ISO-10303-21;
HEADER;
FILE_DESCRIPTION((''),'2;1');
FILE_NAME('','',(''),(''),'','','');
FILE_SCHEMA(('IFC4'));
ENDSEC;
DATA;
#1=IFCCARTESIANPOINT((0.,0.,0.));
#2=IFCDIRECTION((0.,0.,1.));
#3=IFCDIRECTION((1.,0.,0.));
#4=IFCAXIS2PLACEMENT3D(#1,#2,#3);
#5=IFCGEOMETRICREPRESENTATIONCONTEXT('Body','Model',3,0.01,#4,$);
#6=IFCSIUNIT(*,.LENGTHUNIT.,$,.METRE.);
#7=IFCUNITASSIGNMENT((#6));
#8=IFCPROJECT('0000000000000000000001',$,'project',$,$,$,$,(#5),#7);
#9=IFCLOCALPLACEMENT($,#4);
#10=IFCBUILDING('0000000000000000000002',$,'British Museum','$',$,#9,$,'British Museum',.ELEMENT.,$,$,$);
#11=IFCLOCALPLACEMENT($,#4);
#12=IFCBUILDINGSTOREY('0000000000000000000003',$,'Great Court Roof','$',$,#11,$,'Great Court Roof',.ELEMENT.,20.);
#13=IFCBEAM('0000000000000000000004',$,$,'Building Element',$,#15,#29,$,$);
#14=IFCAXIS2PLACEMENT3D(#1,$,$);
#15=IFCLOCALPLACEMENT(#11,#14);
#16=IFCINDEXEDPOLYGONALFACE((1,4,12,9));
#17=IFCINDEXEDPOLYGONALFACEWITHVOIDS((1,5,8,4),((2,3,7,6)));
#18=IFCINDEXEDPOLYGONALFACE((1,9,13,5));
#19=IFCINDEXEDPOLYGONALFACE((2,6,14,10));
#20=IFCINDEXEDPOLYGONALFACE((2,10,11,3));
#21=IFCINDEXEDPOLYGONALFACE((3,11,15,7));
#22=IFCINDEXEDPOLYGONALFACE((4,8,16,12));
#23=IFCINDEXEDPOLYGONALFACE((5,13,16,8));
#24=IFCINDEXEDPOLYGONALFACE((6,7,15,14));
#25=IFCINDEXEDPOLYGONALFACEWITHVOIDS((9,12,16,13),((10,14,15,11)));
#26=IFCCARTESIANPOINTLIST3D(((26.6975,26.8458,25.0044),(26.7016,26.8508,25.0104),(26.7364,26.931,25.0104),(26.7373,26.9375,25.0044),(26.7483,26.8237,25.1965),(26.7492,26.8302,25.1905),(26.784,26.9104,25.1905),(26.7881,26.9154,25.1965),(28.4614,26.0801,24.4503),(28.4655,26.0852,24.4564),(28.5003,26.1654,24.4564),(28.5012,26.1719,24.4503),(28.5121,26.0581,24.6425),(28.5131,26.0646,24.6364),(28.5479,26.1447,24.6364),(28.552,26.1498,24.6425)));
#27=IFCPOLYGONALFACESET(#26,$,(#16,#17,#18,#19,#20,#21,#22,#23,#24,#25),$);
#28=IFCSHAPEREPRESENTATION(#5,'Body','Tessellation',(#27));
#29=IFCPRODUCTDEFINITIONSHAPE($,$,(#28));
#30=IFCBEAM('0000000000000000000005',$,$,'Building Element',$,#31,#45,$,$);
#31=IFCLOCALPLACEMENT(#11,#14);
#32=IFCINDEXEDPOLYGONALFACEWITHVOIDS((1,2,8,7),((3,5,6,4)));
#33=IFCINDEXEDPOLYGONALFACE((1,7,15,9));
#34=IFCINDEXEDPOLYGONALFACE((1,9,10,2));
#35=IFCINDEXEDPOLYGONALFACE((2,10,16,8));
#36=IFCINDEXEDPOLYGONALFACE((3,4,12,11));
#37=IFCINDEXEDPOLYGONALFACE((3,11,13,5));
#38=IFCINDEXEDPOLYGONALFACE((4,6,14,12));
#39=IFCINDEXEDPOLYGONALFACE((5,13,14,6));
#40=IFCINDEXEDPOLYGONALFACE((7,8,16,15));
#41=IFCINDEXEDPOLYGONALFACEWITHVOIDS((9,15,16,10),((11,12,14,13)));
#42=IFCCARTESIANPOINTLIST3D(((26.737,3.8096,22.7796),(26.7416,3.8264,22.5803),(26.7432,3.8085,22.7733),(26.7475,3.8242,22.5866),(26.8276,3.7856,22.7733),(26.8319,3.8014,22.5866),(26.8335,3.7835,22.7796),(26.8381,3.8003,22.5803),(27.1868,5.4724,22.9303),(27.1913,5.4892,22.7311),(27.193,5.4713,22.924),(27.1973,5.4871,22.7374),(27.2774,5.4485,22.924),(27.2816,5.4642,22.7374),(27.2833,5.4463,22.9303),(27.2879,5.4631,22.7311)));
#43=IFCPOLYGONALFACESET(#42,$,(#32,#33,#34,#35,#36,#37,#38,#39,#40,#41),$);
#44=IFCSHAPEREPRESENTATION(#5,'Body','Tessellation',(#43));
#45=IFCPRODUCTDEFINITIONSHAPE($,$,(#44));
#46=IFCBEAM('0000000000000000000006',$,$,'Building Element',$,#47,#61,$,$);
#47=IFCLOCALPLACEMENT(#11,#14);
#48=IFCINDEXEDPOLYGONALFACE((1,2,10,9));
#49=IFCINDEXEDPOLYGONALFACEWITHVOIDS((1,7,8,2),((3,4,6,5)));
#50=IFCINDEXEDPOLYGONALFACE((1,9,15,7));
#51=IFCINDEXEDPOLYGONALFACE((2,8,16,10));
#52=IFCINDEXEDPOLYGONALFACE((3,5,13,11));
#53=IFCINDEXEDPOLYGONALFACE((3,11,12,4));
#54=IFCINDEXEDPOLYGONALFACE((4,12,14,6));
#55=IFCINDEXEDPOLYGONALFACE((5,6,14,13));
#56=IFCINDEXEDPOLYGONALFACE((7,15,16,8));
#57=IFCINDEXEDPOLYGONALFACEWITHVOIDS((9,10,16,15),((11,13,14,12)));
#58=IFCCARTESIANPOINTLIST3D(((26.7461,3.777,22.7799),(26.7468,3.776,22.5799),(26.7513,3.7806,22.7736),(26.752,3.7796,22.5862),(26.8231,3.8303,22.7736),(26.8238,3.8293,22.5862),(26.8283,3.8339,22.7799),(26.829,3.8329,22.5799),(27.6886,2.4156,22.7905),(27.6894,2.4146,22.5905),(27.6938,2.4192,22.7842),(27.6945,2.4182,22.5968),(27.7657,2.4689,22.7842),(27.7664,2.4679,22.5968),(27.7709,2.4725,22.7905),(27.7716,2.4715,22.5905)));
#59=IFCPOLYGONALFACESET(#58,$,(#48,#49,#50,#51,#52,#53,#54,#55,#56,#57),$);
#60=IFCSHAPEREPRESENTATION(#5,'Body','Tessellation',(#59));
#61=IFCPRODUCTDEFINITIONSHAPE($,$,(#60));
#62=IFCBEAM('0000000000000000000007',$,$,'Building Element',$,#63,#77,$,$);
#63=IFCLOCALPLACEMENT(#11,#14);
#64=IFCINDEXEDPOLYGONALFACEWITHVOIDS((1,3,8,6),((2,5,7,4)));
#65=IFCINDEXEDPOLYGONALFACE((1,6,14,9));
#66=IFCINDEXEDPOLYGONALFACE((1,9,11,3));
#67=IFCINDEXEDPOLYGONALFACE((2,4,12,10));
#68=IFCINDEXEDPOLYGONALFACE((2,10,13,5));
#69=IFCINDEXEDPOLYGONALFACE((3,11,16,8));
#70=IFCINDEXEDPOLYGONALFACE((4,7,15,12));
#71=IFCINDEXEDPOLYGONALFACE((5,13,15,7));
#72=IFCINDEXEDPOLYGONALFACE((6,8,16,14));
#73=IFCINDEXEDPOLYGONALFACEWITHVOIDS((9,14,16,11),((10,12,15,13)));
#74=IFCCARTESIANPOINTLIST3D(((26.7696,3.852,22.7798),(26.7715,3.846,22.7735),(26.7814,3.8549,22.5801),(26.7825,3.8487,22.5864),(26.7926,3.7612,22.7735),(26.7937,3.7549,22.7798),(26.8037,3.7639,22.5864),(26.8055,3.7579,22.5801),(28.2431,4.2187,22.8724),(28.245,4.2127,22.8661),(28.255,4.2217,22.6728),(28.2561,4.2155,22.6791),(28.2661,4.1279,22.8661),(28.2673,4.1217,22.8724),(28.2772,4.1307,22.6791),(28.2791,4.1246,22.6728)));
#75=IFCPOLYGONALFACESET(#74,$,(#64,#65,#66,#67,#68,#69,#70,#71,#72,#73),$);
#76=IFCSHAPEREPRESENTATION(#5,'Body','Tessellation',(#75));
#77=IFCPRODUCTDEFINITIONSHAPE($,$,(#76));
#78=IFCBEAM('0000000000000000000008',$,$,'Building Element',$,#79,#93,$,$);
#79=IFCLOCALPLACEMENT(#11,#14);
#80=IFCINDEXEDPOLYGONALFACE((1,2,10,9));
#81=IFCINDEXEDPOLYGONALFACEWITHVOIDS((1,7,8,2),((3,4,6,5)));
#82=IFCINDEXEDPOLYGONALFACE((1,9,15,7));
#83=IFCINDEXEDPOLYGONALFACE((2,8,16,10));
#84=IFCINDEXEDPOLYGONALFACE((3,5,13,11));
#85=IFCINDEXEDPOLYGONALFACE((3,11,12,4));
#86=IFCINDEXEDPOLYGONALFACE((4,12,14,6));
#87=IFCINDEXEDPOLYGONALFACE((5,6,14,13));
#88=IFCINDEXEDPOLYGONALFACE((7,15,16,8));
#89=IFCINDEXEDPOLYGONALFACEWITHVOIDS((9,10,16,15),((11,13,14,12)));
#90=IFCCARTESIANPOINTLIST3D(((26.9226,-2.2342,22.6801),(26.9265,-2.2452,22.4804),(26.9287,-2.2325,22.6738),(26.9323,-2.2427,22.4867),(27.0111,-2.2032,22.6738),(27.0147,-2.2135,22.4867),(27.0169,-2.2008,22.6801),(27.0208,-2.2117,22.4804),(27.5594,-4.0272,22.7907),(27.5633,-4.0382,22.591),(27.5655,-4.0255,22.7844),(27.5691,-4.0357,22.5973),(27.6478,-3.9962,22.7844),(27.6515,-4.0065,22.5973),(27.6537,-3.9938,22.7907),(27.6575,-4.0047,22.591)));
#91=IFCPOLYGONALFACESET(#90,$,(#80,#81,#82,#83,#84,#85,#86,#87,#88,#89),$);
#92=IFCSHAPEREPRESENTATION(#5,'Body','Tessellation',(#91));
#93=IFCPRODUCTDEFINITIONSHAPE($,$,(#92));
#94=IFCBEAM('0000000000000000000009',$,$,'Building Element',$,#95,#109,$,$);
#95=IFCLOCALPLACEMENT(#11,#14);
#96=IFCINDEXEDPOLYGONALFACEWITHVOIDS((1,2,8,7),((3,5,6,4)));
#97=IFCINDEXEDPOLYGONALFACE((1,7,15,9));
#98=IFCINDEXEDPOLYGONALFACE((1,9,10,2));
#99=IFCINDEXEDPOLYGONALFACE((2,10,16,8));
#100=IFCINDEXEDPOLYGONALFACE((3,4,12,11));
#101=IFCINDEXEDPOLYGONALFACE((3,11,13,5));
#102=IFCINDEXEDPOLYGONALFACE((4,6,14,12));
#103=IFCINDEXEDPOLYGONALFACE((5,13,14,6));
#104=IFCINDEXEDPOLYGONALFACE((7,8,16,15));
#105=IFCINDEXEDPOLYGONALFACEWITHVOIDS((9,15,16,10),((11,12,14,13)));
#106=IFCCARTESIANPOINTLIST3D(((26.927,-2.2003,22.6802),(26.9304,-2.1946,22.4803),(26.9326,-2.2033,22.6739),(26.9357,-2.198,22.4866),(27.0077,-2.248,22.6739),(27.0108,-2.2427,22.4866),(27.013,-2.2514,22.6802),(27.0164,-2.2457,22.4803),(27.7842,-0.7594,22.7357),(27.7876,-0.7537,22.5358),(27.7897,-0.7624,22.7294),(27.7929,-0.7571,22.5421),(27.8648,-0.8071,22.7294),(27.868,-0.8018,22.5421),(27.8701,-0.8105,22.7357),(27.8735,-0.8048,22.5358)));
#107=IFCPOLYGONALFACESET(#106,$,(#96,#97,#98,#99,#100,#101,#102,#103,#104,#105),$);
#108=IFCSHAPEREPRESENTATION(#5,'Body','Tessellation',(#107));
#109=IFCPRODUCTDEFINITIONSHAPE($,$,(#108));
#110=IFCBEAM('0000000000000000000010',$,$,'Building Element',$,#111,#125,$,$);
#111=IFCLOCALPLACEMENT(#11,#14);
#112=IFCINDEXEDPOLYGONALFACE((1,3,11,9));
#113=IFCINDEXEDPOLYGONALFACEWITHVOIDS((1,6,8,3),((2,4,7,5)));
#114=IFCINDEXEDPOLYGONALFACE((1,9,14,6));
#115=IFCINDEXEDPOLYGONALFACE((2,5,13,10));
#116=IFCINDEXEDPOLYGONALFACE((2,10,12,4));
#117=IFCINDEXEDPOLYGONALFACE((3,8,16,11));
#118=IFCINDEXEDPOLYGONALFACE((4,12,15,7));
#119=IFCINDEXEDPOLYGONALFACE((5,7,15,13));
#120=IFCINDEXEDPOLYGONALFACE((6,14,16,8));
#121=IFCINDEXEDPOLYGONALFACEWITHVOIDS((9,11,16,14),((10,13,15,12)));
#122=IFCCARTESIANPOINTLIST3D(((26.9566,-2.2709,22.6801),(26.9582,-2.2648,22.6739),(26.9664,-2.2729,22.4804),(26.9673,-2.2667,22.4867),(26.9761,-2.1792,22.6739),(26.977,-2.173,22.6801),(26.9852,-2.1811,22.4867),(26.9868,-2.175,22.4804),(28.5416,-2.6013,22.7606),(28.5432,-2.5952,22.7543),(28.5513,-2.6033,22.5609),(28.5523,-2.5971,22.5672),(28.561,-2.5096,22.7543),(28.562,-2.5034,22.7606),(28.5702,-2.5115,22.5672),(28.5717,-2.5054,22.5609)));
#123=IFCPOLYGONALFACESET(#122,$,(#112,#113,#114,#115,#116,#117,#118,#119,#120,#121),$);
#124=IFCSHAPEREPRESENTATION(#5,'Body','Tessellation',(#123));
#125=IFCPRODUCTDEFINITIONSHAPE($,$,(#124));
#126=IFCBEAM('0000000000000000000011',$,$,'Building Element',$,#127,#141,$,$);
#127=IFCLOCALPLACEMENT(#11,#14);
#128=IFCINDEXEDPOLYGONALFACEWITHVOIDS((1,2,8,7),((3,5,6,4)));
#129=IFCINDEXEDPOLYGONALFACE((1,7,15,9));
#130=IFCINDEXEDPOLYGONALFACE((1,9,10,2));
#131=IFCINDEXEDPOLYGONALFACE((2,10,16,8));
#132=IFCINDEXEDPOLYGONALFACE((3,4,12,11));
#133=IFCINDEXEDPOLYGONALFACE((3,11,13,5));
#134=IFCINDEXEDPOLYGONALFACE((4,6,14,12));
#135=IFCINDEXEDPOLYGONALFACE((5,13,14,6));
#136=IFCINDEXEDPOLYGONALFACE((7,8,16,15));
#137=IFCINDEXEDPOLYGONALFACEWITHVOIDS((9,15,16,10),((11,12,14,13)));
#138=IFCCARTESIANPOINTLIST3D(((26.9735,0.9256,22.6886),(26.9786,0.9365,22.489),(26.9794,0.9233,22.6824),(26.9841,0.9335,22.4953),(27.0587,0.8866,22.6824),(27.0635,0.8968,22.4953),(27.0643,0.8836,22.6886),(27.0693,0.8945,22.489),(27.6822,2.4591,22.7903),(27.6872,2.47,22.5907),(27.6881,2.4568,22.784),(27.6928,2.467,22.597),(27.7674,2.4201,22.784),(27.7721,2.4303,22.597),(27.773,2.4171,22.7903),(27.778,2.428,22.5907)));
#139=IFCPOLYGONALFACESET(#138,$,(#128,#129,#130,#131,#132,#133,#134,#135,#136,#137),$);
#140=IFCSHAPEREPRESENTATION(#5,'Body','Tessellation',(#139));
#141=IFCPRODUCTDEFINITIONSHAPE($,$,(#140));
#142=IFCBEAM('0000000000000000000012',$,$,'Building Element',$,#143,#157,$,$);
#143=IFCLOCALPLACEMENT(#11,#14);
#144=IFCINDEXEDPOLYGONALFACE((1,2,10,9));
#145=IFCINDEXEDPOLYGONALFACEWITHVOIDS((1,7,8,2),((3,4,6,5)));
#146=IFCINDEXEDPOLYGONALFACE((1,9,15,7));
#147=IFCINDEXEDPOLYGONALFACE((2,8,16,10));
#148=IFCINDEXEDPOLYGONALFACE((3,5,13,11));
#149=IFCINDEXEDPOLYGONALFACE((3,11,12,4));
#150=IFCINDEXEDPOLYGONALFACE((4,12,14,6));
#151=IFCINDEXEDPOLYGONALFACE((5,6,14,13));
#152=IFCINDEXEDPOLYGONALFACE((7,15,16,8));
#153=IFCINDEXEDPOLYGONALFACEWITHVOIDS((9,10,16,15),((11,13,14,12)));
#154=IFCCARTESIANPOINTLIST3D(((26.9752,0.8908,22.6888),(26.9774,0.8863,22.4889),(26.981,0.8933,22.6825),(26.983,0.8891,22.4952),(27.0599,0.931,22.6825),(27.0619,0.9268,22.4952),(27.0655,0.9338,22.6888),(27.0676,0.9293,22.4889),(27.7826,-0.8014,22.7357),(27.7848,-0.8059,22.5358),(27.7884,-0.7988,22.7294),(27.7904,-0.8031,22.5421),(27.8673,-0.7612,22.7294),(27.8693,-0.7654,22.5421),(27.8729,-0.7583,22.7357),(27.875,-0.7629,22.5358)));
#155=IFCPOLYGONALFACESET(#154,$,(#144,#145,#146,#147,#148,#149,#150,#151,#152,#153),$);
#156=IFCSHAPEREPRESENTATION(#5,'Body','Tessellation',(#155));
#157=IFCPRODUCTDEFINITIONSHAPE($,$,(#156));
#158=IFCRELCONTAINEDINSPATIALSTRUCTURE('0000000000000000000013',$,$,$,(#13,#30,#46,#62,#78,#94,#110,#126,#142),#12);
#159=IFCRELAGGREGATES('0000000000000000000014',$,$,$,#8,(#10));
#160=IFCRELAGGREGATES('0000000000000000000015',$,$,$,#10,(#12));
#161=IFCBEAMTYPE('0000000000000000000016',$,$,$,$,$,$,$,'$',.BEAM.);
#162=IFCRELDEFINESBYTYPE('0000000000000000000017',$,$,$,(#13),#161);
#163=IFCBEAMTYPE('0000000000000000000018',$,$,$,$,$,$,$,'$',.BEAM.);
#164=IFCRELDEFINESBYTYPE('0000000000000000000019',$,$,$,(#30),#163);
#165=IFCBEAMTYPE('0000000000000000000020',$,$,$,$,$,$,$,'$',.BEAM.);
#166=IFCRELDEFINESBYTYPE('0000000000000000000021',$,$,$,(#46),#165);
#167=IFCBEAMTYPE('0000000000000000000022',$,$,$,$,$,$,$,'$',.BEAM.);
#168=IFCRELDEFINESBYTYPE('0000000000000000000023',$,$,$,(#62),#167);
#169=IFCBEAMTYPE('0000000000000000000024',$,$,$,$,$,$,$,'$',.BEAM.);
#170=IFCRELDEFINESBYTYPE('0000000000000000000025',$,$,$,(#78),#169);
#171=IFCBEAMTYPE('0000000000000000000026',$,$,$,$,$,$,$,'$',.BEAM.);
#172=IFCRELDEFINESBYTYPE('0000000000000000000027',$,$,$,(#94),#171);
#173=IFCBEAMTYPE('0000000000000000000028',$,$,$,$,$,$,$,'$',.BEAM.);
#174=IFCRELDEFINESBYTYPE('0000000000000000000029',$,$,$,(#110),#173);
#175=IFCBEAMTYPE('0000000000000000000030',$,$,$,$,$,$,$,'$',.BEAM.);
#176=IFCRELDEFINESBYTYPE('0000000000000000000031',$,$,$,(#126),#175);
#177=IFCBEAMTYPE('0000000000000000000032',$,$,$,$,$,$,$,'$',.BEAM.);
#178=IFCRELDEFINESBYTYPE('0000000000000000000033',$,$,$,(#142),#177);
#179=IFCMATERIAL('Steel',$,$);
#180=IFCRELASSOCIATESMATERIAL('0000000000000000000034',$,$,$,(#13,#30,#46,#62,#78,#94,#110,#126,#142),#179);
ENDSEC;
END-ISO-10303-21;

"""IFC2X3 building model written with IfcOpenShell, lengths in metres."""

from ifc_helpers import new_model, si_unit, frame, origin_with_axes, origin_2d, place, context, project, spatial, hollow_rectangle, extrude, material, type_object, element, save


model = new_model("IFC2X3")

# Units and contexts
model_context = context("Model", 3, precision=0.01, world=origin_with_axes(), identifier="Body")
ifc_project = project(units=[si_unit("LENGTHUNIT", "METRE")], contexts=[model_context])

# Building, storey
building_placement = place(None, origin_with_axes())
building = spatial("IfcBuilding", under=ifc_project, at=building_placement, Name="British Museum", Description="$", LongName="British Museum", CompositionType="ELEMENT")
storey_placement = place(None, origin_with_axes())
storey = spatial("IfcBuildingStorey", under=building, at=storey_placement, Name="Great Court Roof", Description="$", LongName="Great Court Roof", CompositionType="ELEMENT", Elevation=20.0)

# Beams
ifc_material = material(Name="Steel")
beam_type_1 = type_object("IfcBeamType", ElementType="$", PredefinedType="BEAM")
beam_1_placement = place(None, origin_with_axes())
element("IfcBeam", 1, at=beam_1_placement, inside=storey, type_object=beam_type_1, material=ifc_material, Description="Building Element", context=model_context, shape_type="SweptSolid", body=[
    extrude(hollow_rectangle(XDim=0.1, YDim=0.2, WallThickness=0.0063, InnerFilletRadius=-0.0063, OuterFilletRadius=0.0, at=origin_2d()), frame((26.7428, 26.8806, 25.1005), z_axis=(0.881448, -0.382608, -0.276877), x_axis=(0.398175, 0.91731, 0.0)), (0.0, 0.0, 1.0), 2.0011),
])
beam_type_2 = type_object("IfcBeamType", ElementType="$", PredefinedType="BEAM")
beam_2_placement = place(None, origin_with_axes())
element("IfcBeam", 2, at=beam_2_placement, inside=storey, type_object=beam_type_2, material=ifc_material, Description="Building Element", context=model_context, shape_type="SweptSolid", body=[
    extrude(hollow_rectangle(XDim=0.1, YDim=0.2, WallThickness=0.0063, InnerFilletRadius=-0.0063, OuterFilletRadius=0.0, at=origin_2d()), frame((26.7876, 3.8049, 22.6799), z_axis=(0.260104, 0.961637, 0.087183), x_axis=(-0.965312, 0.261098, 0.0)), (0.0, 0.0, 1.0), 1.7292),
])
beam_type_3 = type_object("IfcBeamType", ElementType="$", PredefinedType="BEAM")
beam_3_placement = place(None, origin_with_axes())
element("IfcBeam", 3, at=beam_3_placement, inside=storey, type_object=beam_type_3, material=ifc_material, Description="Building Element", context=model_context, shape_type="SweptSolid", body=[
    extrude(hollow_rectangle(XDim=0.1, YDim=0.2, WallThickness=0.0063, InnerFilletRadius=-0.0063, OuterFilletRadius=0.0, at=origin_2d()), frame((26.7876, 3.8049, 22.6799), z_axis=(0.569218, -0.822162, 0.006369), x_axis=(0.822178, 0.56923, 0.0)), (0.0, 0.0, 1.0), 1.6559),
])
beam_type_4 = type_object("IfcBeamType", ElementType="$", PredefinedType="BEAM")
beam_4_placement = place(None, origin_with_axes())
element("IfcBeam", 4, at=beam_4_placement, inside=storey, type_object=beam_type_4, material=ifc_material, Description="Building Element", context=model_context, shape_type="SweptSolid", body=[
    extrude(hollow_rectangle(XDim=0.1, YDim=0.2, WallThickness=0.0063, InnerFilletRadius=-0.0063, OuterFilletRadius=0.0, at=origin_2d()), frame((26.7876, 3.8049, 22.6799), z_axis=(0.968596, 0.241063, 0.060918), x_axis=(-0.241512, 0.970398, 0.0)), (0.0, 0.0, 1.0), 1.5213),
])
beam_type_5 = type_object("IfcBeamType", ElementType="$", PredefinedType="BEAM")
beam_5_placement = place(None, origin_with_axes())
element("IfcBeam", 5, at=beam_5_placement, inside=storey, type_object=beam_type_5, material=ifc_material, Description="Building Element", context=model_context, shape_type="SweptSolid", body=[
    extrude(hollow_rectangle(XDim=0.1, YDim=0.2, WallThickness=0.0063, InnerFilletRadius=-0.0063, OuterFilletRadius=0.0, at=origin_2d()), frame((26.9717, -2.223, 22.5803), z_axis=(0.334108, -0.940747, 0.058033), x_axis=(0.942335, 0.334672, 0.0)), (0.0, 0.0, 1.0), 1.9059),
])
beam_type_6 = type_object("IfcBeamType", ElementType="$", PredefinedType="BEAM")
beam_6_placement = place(None, origin_with_axes())
element("IfcBeam", 6, at=beam_6_placement, inside=storey, type_object=beam_type_6, material=ifc_material, Description="Building Element", context=model_context, shape_type="SweptSolid", body=[
    extrude(hollow_rectangle(XDim=0.1, YDim=0.2, WallThickness=0.0063, InnerFilletRadius=-0.0063, OuterFilletRadius=0.0, at=origin_2d()), frame((26.9717, -2.223, 22.5803), z_axis=(0.510977, 0.858958, 0.033064), x_axis=(-0.859428, 0.511257, 0.0)), (0.0, 0.0, 1.0), 1.6774),
])
beam_type_7 = type_object("IfcBeamType", ElementType="$", PredefinedType="BEAM")
beam_7_placement = place(None, origin_with_axes())
element("IfcBeam", 7, at=beam_7_placement, inside=storey, type_object=beam_type_7, material=ifc_material, Description="Building Element", context=model_context, shape_type="SweptSolid", body=[
    extrude(hollow_rectangle(XDim=0.1, YDim=0.2, WallThickness=0.0063, InnerFilletRadius=-0.0063, OuterFilletRadius=0.0, at=origin_2d()), frame((26.9717, -2.223, 22.5803), z_axis=(0.977752, -0.203803, 0.049648), x_axis=(0.204054, 0.97896, 0.0)), (0.0, 0.0, 1.0), 1.621),
])
beam_type_8 = type_object("IfcBeamType", ElementType="$", PredefinedType="BEAM")
beam_8_placement = place(None, origin_with_axes())
element("IfcBeam", 8, at=beam_8_placement, inside=storey, type_object=beam_type_8, material=ifc_material, Description="Building Element", context=model_context, shape_type="SweptSolid", body=[
    extrude(hollow_rectangle(XDim=0.1, YDim=0.2, WallThickness=0.0063, InnerFilletRadius=-0.0063, OuterFilletRadius=0.0, at=origin_2d()), frame((27.0214, 0.9101, 22.5888), z_axis=(0.418739, 0.906117, 0.060072), x_axis=(-0.907757, 0.419497, 0.0)), (0.0, 0.0, 1.0), 1.6924),
])
beam_type_9 = type_object("IfcBeamType", ElementType="$", PredefinedType="BEAM")
beam_9_placement = place(None, origin_with_axes())
element("IfcBeam", 9, at=beam_9_placement, inside=storey, type_object=beam_type_9, material=ifc_material, Description="Building Element", context=model_context, shape_type="SweptSolid", body=[
    extrude(hollow_rectangle(XDim=0.1, YDim=0.2, WallThickness=0.0063, InnerFilletRadius=-0.0063, OuterFilletRadius=0.0, at=origin_2d()), frame((27.0214, 0.9101, 22.5888), z_axis=(0.430492, -0.902248, 0.025012), x_axis=(0.90253, 0.430627, 0.0)), (0.0, 0.0, 1.0), 1.8755),
])

save(model, "model.ifc")
